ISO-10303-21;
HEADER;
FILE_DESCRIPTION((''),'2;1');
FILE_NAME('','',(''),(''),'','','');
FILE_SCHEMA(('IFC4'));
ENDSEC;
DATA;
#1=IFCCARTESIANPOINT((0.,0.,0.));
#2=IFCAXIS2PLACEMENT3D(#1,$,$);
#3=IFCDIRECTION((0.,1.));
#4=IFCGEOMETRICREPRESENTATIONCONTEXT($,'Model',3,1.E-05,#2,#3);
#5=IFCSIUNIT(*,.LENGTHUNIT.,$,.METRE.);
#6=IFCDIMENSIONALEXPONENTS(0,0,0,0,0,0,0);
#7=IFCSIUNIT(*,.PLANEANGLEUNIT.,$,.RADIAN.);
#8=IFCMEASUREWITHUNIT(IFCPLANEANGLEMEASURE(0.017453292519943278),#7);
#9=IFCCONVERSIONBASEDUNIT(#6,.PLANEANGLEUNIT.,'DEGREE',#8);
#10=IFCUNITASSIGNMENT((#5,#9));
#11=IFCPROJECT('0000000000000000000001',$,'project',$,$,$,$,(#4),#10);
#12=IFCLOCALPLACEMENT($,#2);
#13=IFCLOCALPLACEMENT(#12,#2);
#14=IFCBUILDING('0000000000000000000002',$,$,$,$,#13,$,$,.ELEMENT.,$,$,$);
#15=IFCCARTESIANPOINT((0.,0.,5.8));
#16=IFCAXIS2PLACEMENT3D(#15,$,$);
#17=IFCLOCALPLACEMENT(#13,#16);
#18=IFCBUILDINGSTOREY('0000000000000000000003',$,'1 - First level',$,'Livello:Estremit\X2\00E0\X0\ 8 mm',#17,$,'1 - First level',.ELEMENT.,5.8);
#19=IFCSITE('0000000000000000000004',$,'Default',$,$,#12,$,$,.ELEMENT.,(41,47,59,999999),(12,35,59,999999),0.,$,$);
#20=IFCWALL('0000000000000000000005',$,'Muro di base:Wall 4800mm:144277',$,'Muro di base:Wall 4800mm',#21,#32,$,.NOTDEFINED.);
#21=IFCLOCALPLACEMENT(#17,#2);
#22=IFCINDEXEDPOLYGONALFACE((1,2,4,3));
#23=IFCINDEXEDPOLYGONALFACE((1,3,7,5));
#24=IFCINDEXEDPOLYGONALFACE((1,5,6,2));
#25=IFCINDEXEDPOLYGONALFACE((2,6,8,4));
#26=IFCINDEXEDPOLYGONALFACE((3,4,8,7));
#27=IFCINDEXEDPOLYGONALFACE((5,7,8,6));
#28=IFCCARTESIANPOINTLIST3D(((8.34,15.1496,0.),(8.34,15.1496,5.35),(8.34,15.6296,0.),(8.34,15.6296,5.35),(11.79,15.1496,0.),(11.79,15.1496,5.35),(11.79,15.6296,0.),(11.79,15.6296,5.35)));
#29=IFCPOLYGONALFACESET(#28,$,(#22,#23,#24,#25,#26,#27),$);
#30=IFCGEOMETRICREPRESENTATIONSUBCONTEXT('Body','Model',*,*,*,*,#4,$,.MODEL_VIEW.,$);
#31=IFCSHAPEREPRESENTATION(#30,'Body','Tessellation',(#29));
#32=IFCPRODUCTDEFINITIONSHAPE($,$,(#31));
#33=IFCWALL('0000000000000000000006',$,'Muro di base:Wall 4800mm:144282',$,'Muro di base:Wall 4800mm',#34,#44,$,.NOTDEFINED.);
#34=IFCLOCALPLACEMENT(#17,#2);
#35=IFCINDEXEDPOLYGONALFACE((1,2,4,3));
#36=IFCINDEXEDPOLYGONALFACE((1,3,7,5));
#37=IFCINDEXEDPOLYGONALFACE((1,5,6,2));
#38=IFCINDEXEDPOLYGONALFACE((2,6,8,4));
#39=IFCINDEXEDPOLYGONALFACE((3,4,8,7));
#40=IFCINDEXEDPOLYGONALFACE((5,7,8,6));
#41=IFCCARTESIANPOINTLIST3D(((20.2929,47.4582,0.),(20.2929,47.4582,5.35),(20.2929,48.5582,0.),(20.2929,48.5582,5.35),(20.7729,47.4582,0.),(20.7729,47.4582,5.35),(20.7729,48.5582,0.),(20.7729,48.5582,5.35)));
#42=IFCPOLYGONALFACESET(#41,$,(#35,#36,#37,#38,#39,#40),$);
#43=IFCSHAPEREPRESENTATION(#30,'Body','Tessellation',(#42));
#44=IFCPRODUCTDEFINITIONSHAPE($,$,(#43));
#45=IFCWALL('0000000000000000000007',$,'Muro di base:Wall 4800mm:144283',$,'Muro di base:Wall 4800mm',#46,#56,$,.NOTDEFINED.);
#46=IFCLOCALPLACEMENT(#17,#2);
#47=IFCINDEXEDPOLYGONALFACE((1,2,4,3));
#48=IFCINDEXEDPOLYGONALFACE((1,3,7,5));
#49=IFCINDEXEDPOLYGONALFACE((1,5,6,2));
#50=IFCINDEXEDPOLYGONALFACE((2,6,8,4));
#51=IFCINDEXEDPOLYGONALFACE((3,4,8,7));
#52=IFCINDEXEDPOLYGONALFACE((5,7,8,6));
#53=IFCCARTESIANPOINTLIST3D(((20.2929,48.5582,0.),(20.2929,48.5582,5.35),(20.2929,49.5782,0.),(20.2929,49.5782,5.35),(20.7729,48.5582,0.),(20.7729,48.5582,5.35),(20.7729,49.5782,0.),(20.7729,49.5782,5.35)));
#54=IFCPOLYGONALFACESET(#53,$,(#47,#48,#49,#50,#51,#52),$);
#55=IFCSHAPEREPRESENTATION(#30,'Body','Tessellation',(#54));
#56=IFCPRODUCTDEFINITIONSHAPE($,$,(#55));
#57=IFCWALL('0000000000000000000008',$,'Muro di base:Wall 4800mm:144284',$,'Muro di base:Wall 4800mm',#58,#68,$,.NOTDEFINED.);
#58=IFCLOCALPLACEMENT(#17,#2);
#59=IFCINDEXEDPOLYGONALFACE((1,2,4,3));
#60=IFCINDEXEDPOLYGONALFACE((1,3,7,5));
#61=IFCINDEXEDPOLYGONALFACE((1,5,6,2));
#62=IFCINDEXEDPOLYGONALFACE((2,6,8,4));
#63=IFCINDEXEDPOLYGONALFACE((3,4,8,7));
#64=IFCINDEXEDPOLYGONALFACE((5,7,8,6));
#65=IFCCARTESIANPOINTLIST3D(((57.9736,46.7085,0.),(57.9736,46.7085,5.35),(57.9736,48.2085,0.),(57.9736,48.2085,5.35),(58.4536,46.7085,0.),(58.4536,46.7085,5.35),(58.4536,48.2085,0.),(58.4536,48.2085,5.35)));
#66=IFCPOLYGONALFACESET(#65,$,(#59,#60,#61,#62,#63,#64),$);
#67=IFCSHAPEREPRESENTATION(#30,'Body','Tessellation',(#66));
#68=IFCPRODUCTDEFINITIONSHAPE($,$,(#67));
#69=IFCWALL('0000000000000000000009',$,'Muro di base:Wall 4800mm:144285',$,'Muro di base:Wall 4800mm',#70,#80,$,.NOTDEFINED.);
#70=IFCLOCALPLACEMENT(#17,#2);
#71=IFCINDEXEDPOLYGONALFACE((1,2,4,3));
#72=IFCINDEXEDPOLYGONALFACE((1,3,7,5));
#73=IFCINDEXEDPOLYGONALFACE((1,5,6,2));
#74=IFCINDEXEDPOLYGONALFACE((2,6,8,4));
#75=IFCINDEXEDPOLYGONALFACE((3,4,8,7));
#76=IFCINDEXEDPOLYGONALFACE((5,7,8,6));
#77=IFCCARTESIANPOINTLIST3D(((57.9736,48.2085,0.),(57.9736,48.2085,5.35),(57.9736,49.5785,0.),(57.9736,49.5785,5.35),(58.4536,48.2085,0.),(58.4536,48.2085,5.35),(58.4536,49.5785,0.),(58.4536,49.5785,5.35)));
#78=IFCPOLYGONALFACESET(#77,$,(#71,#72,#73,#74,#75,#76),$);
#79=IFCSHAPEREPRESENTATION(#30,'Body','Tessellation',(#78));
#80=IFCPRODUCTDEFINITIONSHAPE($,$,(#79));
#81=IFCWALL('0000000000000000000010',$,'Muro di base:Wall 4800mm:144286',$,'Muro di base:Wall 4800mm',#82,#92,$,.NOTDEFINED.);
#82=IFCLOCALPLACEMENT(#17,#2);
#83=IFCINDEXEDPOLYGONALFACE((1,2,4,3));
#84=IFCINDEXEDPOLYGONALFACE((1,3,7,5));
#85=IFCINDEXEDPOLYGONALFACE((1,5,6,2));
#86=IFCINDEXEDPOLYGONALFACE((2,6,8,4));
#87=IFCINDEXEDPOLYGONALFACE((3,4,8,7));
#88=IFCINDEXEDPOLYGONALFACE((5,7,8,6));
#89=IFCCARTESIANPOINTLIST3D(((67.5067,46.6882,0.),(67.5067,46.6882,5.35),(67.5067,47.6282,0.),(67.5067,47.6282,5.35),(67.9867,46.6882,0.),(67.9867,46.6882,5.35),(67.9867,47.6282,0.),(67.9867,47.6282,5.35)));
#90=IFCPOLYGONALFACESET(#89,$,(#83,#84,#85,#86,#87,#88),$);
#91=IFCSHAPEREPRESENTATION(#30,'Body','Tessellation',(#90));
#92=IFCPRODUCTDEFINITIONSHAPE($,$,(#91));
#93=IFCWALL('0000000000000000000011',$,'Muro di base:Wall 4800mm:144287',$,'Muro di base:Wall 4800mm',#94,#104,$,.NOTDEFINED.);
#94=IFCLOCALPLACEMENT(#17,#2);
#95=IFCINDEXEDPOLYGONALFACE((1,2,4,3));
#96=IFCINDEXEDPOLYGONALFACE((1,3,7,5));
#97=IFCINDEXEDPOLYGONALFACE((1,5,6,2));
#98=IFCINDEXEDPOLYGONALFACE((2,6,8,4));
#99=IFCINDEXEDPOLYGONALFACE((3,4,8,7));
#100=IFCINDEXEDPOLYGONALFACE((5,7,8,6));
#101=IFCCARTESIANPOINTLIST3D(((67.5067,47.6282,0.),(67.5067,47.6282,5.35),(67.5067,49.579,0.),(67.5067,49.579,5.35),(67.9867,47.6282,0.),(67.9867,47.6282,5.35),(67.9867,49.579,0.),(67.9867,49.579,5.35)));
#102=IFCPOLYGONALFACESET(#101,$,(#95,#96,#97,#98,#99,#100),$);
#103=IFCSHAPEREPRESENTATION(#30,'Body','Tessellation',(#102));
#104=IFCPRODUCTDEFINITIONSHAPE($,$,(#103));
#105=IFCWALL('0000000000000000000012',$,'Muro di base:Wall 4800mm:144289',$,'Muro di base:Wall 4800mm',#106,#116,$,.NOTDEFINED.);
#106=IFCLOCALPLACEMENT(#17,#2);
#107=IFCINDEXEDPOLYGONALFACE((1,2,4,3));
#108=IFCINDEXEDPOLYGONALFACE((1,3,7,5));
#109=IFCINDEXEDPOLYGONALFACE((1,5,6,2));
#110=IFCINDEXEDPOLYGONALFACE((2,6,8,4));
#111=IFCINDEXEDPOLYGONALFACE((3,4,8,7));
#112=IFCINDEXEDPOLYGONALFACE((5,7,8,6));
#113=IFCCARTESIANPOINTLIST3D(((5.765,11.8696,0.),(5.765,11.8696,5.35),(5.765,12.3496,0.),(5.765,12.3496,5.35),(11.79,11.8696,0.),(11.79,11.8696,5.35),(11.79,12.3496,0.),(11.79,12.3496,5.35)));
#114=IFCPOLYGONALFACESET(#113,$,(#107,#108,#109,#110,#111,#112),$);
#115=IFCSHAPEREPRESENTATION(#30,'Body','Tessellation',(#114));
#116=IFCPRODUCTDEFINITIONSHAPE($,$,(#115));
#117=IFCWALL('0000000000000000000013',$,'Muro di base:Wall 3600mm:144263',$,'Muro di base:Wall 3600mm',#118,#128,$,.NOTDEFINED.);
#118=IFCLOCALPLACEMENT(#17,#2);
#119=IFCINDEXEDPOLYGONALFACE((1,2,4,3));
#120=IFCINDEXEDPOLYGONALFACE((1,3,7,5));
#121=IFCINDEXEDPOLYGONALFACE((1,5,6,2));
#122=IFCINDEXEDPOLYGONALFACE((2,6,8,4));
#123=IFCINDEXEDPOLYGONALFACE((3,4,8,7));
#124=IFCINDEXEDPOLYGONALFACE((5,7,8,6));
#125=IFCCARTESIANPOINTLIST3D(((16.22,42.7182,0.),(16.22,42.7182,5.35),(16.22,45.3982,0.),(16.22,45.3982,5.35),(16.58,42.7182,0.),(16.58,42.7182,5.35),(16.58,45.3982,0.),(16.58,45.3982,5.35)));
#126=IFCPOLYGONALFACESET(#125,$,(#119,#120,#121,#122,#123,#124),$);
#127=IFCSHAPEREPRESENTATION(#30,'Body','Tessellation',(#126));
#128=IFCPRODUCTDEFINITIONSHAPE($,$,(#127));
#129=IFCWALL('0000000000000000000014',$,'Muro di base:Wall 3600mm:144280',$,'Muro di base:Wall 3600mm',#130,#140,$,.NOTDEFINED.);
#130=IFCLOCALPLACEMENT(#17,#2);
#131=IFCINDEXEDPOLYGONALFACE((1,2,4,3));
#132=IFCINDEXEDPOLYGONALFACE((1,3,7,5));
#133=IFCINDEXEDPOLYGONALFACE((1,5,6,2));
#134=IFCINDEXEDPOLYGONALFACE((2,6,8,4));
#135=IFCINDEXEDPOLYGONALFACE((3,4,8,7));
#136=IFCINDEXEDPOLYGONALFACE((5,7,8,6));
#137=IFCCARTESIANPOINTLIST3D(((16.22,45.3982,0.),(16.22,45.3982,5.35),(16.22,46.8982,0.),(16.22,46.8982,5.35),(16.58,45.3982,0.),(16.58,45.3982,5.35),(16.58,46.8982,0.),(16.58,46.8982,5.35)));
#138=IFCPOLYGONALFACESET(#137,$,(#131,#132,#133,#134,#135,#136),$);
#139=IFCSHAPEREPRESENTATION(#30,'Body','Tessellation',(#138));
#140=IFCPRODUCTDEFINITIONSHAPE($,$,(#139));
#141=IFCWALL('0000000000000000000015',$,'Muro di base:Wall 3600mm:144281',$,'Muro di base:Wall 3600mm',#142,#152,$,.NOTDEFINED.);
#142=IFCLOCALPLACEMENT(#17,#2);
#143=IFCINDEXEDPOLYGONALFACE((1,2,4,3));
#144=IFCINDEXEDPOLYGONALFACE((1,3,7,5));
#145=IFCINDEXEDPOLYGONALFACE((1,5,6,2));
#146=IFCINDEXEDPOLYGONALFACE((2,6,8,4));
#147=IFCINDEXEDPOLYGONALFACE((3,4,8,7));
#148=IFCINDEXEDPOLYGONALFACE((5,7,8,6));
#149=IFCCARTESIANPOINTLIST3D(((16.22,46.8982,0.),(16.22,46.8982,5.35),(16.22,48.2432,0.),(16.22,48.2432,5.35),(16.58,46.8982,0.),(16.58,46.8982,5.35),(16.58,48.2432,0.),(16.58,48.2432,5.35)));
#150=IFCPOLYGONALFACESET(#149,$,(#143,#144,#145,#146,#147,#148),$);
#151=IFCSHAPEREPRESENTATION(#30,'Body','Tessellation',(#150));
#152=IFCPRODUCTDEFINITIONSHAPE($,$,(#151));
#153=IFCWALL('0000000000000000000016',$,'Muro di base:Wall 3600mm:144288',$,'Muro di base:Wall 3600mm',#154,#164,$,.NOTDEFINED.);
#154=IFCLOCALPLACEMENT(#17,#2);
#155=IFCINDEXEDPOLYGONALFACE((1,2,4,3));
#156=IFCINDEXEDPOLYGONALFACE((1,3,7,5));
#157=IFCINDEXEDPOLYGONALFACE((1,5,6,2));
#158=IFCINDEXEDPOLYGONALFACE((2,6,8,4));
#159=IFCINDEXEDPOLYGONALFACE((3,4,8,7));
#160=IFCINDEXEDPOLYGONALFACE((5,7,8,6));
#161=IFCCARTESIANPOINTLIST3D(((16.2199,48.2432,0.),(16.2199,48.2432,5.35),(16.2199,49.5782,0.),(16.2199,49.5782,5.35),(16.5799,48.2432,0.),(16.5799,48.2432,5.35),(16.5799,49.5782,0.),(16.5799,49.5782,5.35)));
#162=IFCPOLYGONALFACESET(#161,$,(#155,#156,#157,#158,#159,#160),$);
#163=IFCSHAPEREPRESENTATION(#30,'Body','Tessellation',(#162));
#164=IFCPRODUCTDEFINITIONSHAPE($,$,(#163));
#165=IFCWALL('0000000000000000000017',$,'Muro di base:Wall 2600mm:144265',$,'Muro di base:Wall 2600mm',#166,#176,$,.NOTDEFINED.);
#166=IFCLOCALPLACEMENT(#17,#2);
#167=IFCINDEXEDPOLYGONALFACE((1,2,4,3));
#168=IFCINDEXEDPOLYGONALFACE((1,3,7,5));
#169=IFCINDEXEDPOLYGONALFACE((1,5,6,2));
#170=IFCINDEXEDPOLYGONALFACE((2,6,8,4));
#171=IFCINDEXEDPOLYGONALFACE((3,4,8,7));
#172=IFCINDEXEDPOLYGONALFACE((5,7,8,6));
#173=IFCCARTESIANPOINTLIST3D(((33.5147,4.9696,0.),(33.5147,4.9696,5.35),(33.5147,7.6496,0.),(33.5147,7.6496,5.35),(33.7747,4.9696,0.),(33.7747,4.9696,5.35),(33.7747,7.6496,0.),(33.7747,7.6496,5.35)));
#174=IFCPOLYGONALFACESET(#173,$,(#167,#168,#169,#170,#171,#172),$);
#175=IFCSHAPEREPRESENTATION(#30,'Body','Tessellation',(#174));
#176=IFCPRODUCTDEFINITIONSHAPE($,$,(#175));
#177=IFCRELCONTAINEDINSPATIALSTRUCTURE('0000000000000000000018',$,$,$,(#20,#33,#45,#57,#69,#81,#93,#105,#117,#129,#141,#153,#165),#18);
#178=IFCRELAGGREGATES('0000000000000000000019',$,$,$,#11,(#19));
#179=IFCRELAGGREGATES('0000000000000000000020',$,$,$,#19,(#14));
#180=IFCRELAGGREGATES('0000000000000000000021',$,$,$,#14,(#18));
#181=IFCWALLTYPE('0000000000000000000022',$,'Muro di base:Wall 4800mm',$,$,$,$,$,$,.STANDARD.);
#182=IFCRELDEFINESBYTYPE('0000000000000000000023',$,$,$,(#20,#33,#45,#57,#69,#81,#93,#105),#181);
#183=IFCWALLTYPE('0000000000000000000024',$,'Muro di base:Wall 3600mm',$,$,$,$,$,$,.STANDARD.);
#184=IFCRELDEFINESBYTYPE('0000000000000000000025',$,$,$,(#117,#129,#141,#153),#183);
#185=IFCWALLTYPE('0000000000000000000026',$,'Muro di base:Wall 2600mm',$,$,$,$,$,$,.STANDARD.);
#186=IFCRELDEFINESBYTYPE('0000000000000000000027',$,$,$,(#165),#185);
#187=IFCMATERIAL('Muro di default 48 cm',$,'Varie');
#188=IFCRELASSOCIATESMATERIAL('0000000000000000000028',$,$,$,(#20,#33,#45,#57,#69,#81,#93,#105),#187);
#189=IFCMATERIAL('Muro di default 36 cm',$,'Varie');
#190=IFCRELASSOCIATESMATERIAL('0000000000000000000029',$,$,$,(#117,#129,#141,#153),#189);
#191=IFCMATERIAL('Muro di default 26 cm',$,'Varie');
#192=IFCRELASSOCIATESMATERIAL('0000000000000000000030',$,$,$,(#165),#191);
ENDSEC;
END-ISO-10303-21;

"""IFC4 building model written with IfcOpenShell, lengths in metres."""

from ifc_helpers import new_model, entity, si_unit, converted_unit, direction, frame, origin, place, context, subcontext, project, spatial, indexed_curve, outline, extrude, material, type_object, element, save


model = new_model("IFC4")

# Units and contexts
model_context = context("Model", 3, precision=1e-05, world=origin(), true_north=direction((0.0, 1.0)))
body_context = subcontext(model_context, "Body", "Model", "MODEL_VIEW")
ifc_project = project(units=[si_unit("LENGTHUNIT", "METRE"), converted_unit("PLANEANGLEUNIT", "DEGREE", entity("IfcPlaneAngleMeasure", 0.017453292519943278), si_unit("PLANEANGLEUNIT", "RADIAN"), dimensions=[0, 0, 0, 0, 0, 0, 0])], contexts=[model_context])

# Site, building, storey
site_placement = place(None, origin())
site = spatial("IfcSite", under=ifc_project, at=site_placement, Name="Default", CompositionType="ELEMENT", RefLatitude=(41, 47, 59, 999999), RefLongitude=(12, 35, 59, 999999), RefElevation=0.0)
building_placement = place(site_placement, origin())
building = spatial("IfcBuilding", under=site, at=building_placement, CompositionType="ELEMENT")
storey_placement = place(building_placement, frame((0.0, 0.0, 5.8)))
storey = spatial("IfcBuildingStorey", under=building, at=storey_placement, Name="1 - First level", ObjectType="Livello:Estremità 8 mm", LongName="1 - First level", CompositionType="ELEMENT", Elevation=5.8)

# Walls
ifc_material_1 = material(Name="Muro di default 48 cm", Category="Varie")
wall_type_1 = type_object("IfcWallType", Name="Muro di base:Wall 4800mm", PredefinedType="STANDARD")
wall_1_placement = place(storey_placement, frame((8.34, 15.3896, 0.0)))
element("IfcWall", 1, at=wall_1_placement, inside=storey, type_object=wall_type_1, material=ifc_material_1, Name="Muro di base:Wall 4800mm:144277", ObjectType="Muro di base:Wall 4800mm", PredefinedType="NOTDEFINED", context=body_context, shape_type="SweptSolid", body=[
    extrude(outline(indexed_curve([(3.45, 0.24), (0.0, 0.24), (0.0, -0.24), (3.45, -0.24), (3.45, 0.24)], self_intersect=False)), origin(), (0.0, 0.0, 1.0), 5.35),
])
wall_2_placement = place(storey_placement, frame((20.5329, 47.4582, 0.0), z_axis=(0.0, 0.0, 1.0), x_axis=(0.0, 1.0, 0.0)))
element("IfcWall", 2, at=wall_2_placement, inside=storey, type_object=wall_type_1, material=ifc_material_1, Name="Muro di base:Wall 4800mm:144282", ObjectType="Muro di base:Wall 4800mm", PredefinedType="NOTDEFINED", context=body_context, shape_type="SweptSolid", body=[
    extrude(outline(indexed_curve([(1.1, 0.24), (0.0, 0.24), (0.0, -0.24), (1.1, -0.24), (1.1, 0.24)], self_intersect=False)), origin(), (0.0, 0.0, 1.0), 5.35),
])
wall_3_placement = place(storey_placement, frame((20.5329, 48.5582, 0.0), z_axis=(0.0, 0.0, 1.0), x_axis=(0.0, 1.0, 0.0)))
element("IfcWall", 3, at=wall_3_placement, inside=storey, type_object=wall_type_1, material=ifc_material_1, Name="Muro di base:Wall 4800mm:144283", ObjectType="Muro di base:Wall 4800mm", PredefinedType="NOTDEFINED", context=body_context, shape_type="SweptSolid", body=[
    extrude(outline(indexed_curve([(1.02, 0.24), (0.0, 0.24), (0.0, -0.24), (1.02, -0.24), (1.02, 0.24)], self_intersect=False)), origin(), (0.0, 0.0, 1.0), 5.35),
])
wall_4_placement = place(storey_placement, frame((58.2136, 46.7085, 0.0), z_axis=(0.0, 0.0, 1.0), x_axis=(0.0, 1.0, 0.0)))
element("IfcWall", 4, at=wall_4_placement, inside=storey, type_object=wall_type_1, material=ifc_material_1, Name="Muro di base:Wall 4800mm:144284", ObjectType="Muro di base:Wall 4800mm", PredefinedType="NOTDEFINED", context=body_context, shape_type="SweptSolid", body=[
    extrude(outline(indexed_curve([(1.5, 0.24), (0.0, 0.24), (0.0, -0.24), (1.5, -0.24), (1.5, 0.24)], self_intersect=False)), origin(), (0.0, 0.0, 1.0), 5.35),
])
wall_5_placement = place(storey_placement, frame((58.2136, 48.2085, 0.0), z_axis=(0.0, 0.0, 1.0), x_axis=(0.0, 1.0, 0.0)))
element("IfcWall", 5, at=wall_5_placement, inside=storey, type_object=wall_type_1, material=ifc_material_1, Name="Muro di base:Wall 4800mm:144285", ObjectType="Muro di base:Wall 4800mm", PredefinedType="NOTDEFINED", context=body_context, shape_type="SweptSolid", body=[
    extrude(outline(indexed_curve([(1.37, 0.24), (0.0, 0.24), (0.0, -0.24), (1.37, -0.24), (1.37, 0.24)], self_intersect=False)), origin(), (0.0, 0.0, 1.0), 5.35),
])
wall_6_placement = place(storey_placement, frame((67.7467, 46.6882, 0.0), z_axis=(0.0, 0.0, 1.0), x_axis=(0.0, 1.0, 0.0)))
element("IfcWall", 6, at=wall_6_placement, inside=storey, type_object=wall_type_1, material=ifc_material_1, Name="Muro di base:Wall 4800mm:144286", ObjectType="Muro di base:Wall 4800mm", PredefinedType="NOTDEFINED", context=body_context, shape_type="SweptSolid", body=[
    extrude(outline(indexed_curve([(0.94, 0.24), (0.0, 0.24), (0.0, -0.24), (0.94, -0.24), (0.94, 0.24)], self_intersect=False)), origin(), (0.0, 0.0, 1.0), 5.35),
])
wall_7_placement = place(storey_placement, frame((67.7467, 47.6282, 0.0), z_axis=(0.0, 0.0, 1.0), x_axis=(0.0, 1.0, 0.0)))
element("IfcWall", 7, at=wall_7_placement, inside=storey, type_object=wall_type_1, material=ifc_material_1, Name="Muro di base:Wall 4800mm:144287", ObjectType="Muro di base:Wall 4800mm", PredefinedType="NOTDEFINED", context=body_context, shape_type="SweptSolid", body=[
    extrude(outline(indexed_curve([(1.9508, 0.24), (0.0, 0.24), (0.0, -0.24), (1.9508, -0.24), (1.9508, 0.24)], self_intersect=False)), origin(), (0.0, 0.0, 1.0), 5.35),
])
wall_8_placement = place(storey_placement, frame((5.765, 12.1096, 0.0)))
element("IfcWall", 8, at=wall_8_placement, inside=storey, type_object=wall_type_1, material=ifc_material_1, Name="Muro di base:Wall 4800mm:144289", ObjectType="Muro di base:Wall 4800mm", PredefinedType="NOTDEFINED", context=body_context, shape_type="SweptSolid", body=[
    extrude(outline(indexed_curve([(6.025, 0.24), (0.0, 0.24), (0.0, -0.24), (6.025, -0.24), (6.025, 0.24)], self_intersect=False)), origin(), (0.0, 0.0, 1.0), 5.35),
])
ifc_material_2 = material(Name="Muro di default 36 cm", Category="Varie")
wall_type_2 = type_object("IfcWallType", Name="Muro di base:Wall 3600mm", PredefinedType="STANDARD")
wall_9_placement = place(storey_placement, frame((16.4, 42.7182, 0.0), z_axis=(0.0, 0.0, 1.0), x_axis=(0.0, 1.0, 0.0)))
element("IfcWall", 9, at=wall_9_placement, inside=storey, type_object=wall_type_2, material=ifc_material_2, Name="Muro di base:Wall 3600mm:144263", ObjectType="Muro di base:Wall 3600mm", PredefinedType="NOTDEFINED", context=body_context, shape_type="SweptSolid", body=[
    extrude(outline(indexed_curve([(2.68, 0.18), (0.0, 0.18), (0.0, -0.18), (2.68, -0.18), (2.68, 0.18)], self_intersect=False)), origin(), (0.0, 0.0, 1.0), 5.35),
])
wall_10_placement = place(storey_placement, frame((16.4, 45.3982, 0.0), z_axis=(0.0, 0.0, 1.0), x_axis=(0.0, 1.0, 0.0)))
element("IfcWall", 10, at=wall_10_placement, inside=storey, type_object=wall_type_2, material=ifc_material_2, Name="Muro di base:Wall 3600mm:144280", ObjectType="Muro di base:Wall 3600mm", PredefinedType="NOTDEFINED", context=body_context, shape_type="SweptSolid", body=[
    extrude(outline(indexed_curve([(1.5, 0.18), (0.0, 0.18), (0.0, -0.18), (1.5, -0.18), (1.5, 0.18)], self_intersect=False)), origin(), (0.0, 0.0, 1.0), 5.35),
])
wall_11_placement = place(storey_placement, frame((16.4, 46.8982, 0.0), z_axis=(0.0, 0.0, 1.0), x_axis=(0.0, 1.0, 0.0)))
element("IfcWall", 11, at=wall_11_placement, inside=storey, type_object=wall_type_2, material=ifc_material_2, Name="Muro di base:Wall 3600mm:144281", ObjectType="Muro di base:Wall 3600mm", PredefinedType="NOTDEFINED", context=body_context, shape_type="SweptSolid", body=[
    extrude(outline(indexed_curve([(1.345, 0.18), (0.0, 0.18), (0.0, -0.18), (1.345, -0.18), (1.345, 0.18)], self_intersect=False)), origin(), (0.0, 0.0, 1.0), 5.35),
])
wall_12_placement = place(storey_placement, frame((16.3999, 48.2432, 0.0), z_axis=(0.0, 0.0, 1.0), x_axis=(0.0, 1.0, 0.0)))
element("IfcWall", 12, at=wall_12_placement, inside=storey, type_object=wall_type_2, material=ifc_material_2, Name="Muro di base:Wall 3600mm:144288", ObjectType="Muro di base:Wall 3600mm", PredefinedType="NOTDEFINED", context=body_context, shape_type="SweptSolid", body=[
    extrude(outline(indexed_curve([(1.335, 0.18), (0.0, 0.18), (0.0, -0.18), (1.335, -0.18), (1.335, 0.18)], self_intersect=False)), origin(), (0.0, 0.0, 1.0), 5.35),
])
ifc_material_3 = material(Name="Muro di default 26 cm", Category="Varie")
wall_type_3 = type_object("IfcWallType", Name="Muro di base:Wall 2600mm", PredefinedType="STANDARD")
wall_13_placement = place(storey_placement, frame((33.6447, 4.9696, 0.0), z_axis=(0.0, 0.0, 1.0), x_axis=(0.0, 1.0, 0.0)))
element("IfcWall", 13, at=wall_13_placement, inside=storey, type_object=wall_type_3, material=ifc_material_3, Name="Muro di base:Wall 2600mm:144265", ObjectType="Muro di base:Wall 2600mm", PredefinedType="NOTDEFINED", context=body_context, shape_type="SweptSolid", body=[
    extrude(outline(indexed_curve([(2.68, 0.13), (0.0, 0.13), (0.0, -0.13), (2.68, -0.13), (2.68, 0.13)], self_intersect=False)), origin(), (0.0, 0.0, 1.0), 5.35),
])

save(model, "model.ifc")
